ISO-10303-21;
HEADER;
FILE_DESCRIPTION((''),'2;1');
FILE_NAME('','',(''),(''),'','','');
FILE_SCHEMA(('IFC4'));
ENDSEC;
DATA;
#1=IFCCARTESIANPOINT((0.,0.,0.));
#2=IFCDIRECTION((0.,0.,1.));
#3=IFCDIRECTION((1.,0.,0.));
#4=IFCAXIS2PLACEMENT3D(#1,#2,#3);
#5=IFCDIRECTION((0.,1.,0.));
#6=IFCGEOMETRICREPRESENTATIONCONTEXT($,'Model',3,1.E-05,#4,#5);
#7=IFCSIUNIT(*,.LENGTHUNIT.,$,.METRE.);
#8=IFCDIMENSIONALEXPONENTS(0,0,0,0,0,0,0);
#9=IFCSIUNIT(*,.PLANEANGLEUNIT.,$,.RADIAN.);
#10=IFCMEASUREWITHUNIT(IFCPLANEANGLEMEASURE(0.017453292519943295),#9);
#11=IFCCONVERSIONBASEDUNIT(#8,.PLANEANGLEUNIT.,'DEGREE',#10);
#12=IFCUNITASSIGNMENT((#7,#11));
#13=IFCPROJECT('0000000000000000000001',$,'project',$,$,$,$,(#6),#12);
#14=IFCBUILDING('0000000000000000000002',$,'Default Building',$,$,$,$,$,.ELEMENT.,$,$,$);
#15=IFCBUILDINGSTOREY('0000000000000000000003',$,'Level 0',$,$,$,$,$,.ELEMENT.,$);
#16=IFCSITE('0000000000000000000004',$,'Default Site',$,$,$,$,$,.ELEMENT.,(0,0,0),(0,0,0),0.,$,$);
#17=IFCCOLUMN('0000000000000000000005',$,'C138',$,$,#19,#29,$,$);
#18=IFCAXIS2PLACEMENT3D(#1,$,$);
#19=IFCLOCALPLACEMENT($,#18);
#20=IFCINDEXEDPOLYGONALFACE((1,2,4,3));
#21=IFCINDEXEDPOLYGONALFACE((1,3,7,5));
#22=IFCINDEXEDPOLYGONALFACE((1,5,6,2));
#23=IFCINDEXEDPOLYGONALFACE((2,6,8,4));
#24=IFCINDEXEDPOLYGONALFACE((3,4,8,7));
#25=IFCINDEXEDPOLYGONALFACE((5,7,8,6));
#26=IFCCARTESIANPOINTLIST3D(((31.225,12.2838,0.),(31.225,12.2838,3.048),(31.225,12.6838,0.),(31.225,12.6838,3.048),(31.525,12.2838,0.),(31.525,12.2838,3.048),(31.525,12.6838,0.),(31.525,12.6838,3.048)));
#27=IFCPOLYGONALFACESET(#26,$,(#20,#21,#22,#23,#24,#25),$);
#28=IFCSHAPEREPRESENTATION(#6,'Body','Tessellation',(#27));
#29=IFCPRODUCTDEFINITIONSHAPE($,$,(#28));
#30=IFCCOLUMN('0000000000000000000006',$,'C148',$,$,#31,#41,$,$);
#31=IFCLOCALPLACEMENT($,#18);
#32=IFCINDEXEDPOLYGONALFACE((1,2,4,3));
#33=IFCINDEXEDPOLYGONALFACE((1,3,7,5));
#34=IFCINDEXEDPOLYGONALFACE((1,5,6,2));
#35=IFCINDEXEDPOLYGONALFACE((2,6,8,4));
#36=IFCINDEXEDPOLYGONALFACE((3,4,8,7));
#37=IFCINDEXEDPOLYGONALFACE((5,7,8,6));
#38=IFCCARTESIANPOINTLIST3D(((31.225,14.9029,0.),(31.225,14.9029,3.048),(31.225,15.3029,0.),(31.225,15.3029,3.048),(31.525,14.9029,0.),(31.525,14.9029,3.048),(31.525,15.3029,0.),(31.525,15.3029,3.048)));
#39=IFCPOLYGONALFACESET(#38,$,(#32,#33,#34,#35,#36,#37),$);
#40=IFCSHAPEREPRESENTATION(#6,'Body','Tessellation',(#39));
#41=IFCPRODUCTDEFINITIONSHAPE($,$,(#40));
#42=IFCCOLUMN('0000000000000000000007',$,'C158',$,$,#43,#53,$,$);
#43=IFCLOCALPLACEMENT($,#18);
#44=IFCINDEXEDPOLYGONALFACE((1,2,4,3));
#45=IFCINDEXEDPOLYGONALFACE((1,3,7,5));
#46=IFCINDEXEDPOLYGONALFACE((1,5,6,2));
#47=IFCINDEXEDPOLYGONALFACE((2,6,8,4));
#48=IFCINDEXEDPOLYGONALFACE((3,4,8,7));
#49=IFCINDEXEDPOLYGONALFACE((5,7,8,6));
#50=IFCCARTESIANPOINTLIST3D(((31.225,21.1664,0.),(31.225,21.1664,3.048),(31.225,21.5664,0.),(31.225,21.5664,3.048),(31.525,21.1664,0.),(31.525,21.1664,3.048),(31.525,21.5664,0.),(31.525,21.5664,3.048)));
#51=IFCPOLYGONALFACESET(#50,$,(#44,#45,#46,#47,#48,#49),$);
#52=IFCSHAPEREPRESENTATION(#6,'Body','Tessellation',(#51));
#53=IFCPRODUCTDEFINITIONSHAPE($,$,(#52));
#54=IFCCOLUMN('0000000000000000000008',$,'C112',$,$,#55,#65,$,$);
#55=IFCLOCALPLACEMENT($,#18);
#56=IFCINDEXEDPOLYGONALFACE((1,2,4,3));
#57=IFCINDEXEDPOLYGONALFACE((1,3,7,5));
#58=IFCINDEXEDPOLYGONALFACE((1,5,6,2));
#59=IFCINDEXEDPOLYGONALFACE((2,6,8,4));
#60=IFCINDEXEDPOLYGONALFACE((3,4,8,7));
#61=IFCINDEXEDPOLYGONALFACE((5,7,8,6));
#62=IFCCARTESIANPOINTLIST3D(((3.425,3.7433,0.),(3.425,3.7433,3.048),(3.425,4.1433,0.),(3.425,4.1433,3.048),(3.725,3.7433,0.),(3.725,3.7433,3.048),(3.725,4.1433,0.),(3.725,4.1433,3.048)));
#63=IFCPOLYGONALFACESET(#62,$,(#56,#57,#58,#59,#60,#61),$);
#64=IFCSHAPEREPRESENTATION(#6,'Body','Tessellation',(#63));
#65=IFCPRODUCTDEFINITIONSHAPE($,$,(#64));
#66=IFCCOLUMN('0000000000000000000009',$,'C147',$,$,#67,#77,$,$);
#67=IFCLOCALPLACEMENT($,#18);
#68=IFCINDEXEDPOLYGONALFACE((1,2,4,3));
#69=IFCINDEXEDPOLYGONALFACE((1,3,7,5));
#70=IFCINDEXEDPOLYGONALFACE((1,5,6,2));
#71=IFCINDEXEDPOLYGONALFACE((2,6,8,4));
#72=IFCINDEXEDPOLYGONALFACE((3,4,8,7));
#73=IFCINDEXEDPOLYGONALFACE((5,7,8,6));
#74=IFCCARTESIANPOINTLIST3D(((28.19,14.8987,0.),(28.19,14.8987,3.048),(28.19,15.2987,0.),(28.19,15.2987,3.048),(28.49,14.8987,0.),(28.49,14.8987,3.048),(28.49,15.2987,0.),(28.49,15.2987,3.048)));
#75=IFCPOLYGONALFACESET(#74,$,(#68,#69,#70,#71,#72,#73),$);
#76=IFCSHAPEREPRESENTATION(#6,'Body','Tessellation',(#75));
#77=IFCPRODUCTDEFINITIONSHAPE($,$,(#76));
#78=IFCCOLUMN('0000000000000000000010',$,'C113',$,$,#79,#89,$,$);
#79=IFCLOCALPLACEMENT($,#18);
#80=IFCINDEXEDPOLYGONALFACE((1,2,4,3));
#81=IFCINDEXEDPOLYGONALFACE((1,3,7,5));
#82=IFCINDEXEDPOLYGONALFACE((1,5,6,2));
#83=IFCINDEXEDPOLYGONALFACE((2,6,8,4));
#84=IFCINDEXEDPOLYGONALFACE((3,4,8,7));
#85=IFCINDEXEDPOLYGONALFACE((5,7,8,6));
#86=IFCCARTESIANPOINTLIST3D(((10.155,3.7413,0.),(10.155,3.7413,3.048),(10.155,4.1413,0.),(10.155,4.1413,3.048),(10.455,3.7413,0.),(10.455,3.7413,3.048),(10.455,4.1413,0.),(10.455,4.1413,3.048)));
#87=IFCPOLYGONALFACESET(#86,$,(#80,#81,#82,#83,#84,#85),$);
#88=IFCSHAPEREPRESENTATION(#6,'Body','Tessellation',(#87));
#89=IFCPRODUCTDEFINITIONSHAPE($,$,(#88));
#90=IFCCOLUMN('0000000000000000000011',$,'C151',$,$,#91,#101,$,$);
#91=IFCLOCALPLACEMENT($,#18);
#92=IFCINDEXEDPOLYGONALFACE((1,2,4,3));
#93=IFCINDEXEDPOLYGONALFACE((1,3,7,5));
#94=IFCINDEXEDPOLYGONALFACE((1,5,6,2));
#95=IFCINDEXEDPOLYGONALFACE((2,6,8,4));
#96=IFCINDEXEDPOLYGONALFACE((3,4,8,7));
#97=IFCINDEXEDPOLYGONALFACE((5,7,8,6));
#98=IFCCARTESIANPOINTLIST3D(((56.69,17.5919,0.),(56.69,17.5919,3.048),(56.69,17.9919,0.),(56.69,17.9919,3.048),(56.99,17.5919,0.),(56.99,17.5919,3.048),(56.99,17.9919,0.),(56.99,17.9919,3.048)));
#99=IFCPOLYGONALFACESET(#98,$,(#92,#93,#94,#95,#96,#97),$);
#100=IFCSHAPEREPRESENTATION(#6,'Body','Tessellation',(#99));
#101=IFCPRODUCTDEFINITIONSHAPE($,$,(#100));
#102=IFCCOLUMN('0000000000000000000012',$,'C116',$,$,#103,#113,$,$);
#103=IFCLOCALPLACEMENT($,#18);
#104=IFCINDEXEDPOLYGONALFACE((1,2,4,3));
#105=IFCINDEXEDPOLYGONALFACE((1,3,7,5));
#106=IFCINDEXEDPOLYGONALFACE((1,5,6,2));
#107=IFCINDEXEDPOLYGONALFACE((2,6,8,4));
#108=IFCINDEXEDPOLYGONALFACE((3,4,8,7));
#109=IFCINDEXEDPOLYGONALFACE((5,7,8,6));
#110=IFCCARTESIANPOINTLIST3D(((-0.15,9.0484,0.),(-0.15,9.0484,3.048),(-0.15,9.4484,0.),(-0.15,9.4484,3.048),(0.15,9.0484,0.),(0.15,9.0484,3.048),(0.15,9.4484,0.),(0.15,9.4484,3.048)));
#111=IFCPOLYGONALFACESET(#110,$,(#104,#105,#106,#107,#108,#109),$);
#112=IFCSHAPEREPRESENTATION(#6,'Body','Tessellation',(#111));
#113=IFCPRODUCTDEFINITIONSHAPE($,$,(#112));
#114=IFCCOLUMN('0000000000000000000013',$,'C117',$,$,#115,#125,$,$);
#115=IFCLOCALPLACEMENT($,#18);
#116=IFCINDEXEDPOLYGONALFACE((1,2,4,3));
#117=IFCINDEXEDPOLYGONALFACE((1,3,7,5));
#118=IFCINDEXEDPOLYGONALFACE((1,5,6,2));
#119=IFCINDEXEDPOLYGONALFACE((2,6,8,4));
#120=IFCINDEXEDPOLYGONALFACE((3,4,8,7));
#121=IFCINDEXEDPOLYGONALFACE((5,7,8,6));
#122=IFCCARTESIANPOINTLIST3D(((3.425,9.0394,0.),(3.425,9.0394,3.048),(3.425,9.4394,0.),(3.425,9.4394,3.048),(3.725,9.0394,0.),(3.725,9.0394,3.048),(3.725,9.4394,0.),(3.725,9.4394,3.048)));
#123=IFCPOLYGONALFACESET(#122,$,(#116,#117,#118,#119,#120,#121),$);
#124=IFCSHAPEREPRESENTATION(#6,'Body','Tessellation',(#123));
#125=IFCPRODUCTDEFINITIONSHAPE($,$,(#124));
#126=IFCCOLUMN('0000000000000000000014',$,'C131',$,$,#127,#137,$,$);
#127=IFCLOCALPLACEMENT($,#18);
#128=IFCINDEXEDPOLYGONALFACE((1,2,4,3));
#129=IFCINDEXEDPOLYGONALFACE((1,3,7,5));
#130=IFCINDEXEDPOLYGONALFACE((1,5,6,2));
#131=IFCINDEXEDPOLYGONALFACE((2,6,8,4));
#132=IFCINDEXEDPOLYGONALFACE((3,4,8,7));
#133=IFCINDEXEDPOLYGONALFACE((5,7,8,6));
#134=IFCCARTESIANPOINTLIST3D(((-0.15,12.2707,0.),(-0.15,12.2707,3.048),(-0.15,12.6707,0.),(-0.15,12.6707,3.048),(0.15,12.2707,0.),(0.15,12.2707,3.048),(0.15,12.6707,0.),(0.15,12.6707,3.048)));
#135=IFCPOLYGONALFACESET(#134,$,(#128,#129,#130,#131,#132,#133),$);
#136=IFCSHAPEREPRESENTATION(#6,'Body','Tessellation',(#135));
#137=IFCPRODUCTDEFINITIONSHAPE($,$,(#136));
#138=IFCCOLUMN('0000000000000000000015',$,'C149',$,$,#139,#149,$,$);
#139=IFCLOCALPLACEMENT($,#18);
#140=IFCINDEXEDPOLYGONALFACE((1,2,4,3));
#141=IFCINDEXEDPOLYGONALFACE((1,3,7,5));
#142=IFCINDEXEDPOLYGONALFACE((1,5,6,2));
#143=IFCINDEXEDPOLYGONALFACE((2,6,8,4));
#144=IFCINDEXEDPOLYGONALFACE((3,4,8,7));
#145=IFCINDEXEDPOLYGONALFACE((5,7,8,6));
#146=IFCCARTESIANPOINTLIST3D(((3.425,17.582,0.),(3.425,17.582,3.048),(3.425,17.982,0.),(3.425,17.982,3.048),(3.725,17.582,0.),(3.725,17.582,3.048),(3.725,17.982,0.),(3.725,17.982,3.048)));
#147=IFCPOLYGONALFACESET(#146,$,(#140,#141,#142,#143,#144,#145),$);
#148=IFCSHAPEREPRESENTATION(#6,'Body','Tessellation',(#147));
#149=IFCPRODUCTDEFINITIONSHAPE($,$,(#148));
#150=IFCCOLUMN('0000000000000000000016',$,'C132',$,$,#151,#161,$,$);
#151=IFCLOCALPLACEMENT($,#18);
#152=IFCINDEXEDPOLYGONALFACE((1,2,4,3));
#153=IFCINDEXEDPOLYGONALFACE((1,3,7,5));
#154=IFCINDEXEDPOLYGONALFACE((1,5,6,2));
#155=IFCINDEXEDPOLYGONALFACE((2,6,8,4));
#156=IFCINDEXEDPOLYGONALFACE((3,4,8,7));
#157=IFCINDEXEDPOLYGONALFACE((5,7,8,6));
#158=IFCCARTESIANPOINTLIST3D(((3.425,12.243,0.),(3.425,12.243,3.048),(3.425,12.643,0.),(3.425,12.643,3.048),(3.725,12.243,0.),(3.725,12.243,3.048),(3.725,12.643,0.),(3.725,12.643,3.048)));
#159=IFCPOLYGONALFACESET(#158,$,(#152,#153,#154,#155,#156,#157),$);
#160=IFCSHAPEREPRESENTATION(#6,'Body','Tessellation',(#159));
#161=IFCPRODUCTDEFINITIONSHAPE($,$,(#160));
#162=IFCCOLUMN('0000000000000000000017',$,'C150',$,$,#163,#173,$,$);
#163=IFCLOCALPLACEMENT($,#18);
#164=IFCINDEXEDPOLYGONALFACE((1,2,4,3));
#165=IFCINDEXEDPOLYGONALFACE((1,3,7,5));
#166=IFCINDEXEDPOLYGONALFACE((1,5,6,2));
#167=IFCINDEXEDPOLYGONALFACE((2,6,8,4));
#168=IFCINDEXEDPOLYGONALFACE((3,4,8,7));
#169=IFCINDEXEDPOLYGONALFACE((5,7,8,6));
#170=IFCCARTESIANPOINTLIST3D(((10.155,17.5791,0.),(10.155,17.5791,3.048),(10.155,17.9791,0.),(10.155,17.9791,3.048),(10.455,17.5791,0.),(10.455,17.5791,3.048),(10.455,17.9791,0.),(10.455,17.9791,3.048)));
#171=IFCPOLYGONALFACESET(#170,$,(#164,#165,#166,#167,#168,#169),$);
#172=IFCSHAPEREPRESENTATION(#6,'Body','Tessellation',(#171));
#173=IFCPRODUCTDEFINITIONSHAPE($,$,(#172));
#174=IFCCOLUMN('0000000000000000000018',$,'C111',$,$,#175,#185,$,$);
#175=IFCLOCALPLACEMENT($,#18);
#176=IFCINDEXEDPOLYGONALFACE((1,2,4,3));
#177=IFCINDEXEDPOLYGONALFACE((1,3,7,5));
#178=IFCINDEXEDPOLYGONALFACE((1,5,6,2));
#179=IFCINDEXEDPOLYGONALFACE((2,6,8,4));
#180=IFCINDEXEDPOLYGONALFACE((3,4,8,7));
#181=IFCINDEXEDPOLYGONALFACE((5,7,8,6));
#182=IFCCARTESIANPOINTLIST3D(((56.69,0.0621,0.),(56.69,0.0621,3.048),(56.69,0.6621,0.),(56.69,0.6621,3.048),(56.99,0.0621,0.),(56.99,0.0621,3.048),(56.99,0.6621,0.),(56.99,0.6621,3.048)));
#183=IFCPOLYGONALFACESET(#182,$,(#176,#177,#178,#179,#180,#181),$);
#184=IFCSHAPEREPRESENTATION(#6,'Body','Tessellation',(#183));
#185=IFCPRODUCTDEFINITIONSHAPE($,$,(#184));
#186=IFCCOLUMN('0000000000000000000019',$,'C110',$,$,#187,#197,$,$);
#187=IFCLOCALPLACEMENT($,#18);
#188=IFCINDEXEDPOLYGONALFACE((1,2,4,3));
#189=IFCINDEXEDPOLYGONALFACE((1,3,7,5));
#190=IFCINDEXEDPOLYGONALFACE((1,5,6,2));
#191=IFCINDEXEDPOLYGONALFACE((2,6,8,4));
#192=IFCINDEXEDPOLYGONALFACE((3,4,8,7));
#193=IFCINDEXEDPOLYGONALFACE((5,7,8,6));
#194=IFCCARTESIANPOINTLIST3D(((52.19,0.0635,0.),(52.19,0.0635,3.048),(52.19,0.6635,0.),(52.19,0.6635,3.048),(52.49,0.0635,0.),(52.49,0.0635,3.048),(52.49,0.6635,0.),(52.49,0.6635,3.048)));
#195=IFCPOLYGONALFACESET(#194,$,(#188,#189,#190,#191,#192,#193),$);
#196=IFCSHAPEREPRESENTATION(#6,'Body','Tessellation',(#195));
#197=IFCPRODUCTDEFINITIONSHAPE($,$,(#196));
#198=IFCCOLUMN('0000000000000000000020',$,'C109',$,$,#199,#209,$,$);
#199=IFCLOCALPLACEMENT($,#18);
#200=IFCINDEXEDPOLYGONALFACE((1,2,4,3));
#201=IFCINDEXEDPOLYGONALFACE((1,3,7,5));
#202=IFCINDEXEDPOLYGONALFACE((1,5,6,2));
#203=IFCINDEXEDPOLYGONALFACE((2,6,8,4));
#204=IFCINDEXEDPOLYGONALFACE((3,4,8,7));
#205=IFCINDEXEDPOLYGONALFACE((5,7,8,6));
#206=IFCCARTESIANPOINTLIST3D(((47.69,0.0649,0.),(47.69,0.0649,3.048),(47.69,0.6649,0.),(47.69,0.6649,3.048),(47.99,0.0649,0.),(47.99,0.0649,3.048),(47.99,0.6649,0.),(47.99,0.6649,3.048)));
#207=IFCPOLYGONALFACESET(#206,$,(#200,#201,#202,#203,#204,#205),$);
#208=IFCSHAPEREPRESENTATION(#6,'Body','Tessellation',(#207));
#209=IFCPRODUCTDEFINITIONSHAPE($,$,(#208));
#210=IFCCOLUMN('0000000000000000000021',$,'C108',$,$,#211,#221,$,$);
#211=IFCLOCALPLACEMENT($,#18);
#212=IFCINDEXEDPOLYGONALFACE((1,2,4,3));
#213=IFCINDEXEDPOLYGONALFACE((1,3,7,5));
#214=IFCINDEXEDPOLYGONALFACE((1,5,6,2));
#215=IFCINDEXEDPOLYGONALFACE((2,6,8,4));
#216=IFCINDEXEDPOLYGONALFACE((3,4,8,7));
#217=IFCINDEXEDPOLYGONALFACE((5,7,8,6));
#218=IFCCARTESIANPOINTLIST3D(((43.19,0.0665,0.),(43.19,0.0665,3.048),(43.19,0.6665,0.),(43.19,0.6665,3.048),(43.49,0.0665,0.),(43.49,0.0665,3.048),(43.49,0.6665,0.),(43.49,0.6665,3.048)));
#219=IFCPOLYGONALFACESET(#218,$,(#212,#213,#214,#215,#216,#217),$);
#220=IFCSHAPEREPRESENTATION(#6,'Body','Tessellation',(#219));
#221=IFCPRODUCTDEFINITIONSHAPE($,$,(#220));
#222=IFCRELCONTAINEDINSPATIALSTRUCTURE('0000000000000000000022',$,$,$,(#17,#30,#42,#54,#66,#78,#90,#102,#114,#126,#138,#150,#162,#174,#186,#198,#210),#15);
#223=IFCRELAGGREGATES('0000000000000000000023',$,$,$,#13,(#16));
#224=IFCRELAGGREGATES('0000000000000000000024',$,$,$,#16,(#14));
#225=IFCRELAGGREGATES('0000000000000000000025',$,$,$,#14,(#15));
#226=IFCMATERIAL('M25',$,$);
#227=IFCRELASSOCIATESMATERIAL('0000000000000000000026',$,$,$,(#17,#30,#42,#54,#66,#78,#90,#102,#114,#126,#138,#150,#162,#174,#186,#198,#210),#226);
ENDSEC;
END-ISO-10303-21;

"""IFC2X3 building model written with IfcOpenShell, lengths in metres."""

from ifc_helpers import new_model, entity, si_unit, converted_unit, direction, frame, frame_2d, origin_with_axes, place, context, project, spatial, rectangle, extrude, material, element, save


model = new_model("IFC2X3")

# Units and contexts
model_context = context("Model", 3, precision=1e-05, world=origin_with_axes(), true_north=direction((0.0, 1.0, 0.0)))
ifc_project = project(units=[si_unit("LENGTHUNIT", "METRE"), converted_unit("PLANEANGLEUNIT", "DEGREE", entity("IfcPlaneAngleMeasure", 0.017453292519943295), si_unit("PLANEANGLEUNIT", "RADIAN"), dimensions=[0, 0, 0, 0, 0, 0, 0])], contexts=[model_context])

# Site, building, storey
site = spatial("IfcSite", under=ifc_project, Name="Default Site", CompositionType="ELEMENT", RefLatitude=(0, 0, 0), RefLongitude=(0, 0, 0), RefElevation=0.0)
building = spatial("IfcBuilding", under=site, Name="Default Building", CompositionType="ELEMENT")
storey = spatial("IfcBuildingStorey", under=building, Name="Level 0", CompositionType="ELEMENT")

# Columns
ifc_material = material(Name="M25")
placement = place(None, origin_with_axes())
element("IfcColumn", 1, at=placement, inside=storey, material=ifc_material, Name="C138", context=model_context, shape_type="SweptSolid", body=[
    extrude(rectangle(XDim=0.3, YDim=0.4, at=frame_2d((0.0, 0.0), x_axis=(1.0, 0.0, 0.0))), frame((31.375, 12.4838, 0.0), z_axis=(0.0, 0.0, 1.0), x_axis=(1.0, 0.0, 0.0)), (0.0, 0.0, 1.0), 3.048),
])
element("IfcColumn", 2, at=placement, inside=storey, material=ifc_material, Name="C148", context=model_context, shape_type="SweptSolid", body=[
    extrude(rectangle(XDim=0.3, YDim=0.4, at=frame_2d((0.0, 0.0), x_axis=(1.0, 0.0, 0.0))), frame((31.375, 15.1029, 0.0), z_axis=(0.0, 0.0, 1.0), x_axis=(1.0, 0.0, 0.0)), (0.0, 0.0, 1.0), 3.048),
])
element("IfcColumn", 3, at=placement, inside=storey, material=ifc_material, Name="C158", context=model_context, shape_type="SweptSolid", body=[
    extrude(rectangle(XDim=0.3, YDim=0.4, at=frame_2d((0.0, 0.0), x_axis=(1.0, 0.0, 0.0))), frame((31.375, 21.3664, 0.0), z_axis=(0.0, 0.0, 1.0), x_axis=(1.0, 0.0, 0.0)), (0.0, 0.0, 1.0), 3.048),
])
element("IfcColumn", 4, at=placement, inside=storey, material=ifc_material, Name="C112", context=model_context, shape_type="SweptSolid", body=[
    extrude(rectangle(XDim=0.3, YDim=0.4, at=frame_2d((0.0, 0.0), x_axis=(1.0, 0.0, 0.0))), frame((3.575, 3.9433, 0.0), z_axis=(0.0, 0.0, 1.0), x_axis=(1.0, 0.0, 0.0)), (0.0, 0.0, 1.0), 3.048),
])
element("IfcColumn", 5, at=placement, inside=storey, material=ifc_material, Name="C147", context=model_context, shape_type="SweptSolid", body=[
    extrude(rectangle(XDim=0.3, YDim=0.4, at=frame_2d((0.0, 0.0), x_axis=(1.0, 0.0, 0.0))), frame((28.34, 15.0987, 0.0), z_axis=(0.0, 0.0, 1.0), x_axis=(1.0, 0.0, 0.0)), (0.0, 0.0, 1.0), 3.048),
])
element("IfcColumn", 6, at=placement, inside=storey, material=ifc_material, Name="C113", context=model_context, shape_type="SweptSolid", body=[
    extrude(rectangle(XDim=0.3, YDim=0.4, at=frame_2d((0.0, 0.0), x_axis=(1.0, 0.0, 0.0))), frame((10.305, 3.9413, 0.0), z_axis=(0.0, 0.0, 1.0), x_axis=(1.0, 0.0, 0.0)), (0.0, 0.0, 1.0), 3.048),
])
element("IfcColumn", 7, at=placement, inside=storey, material=ifc_material, Name="C151", context=model_context, shape_type="SweptSolid", body=[
    extrude(rectangle(XDim=0.3, YDim=0.4, at=frame_2d((0.0, 0.0), x_axis=(1.0, 0.0, 0.0))), frame((56.84, 17.7919, 0.0), z_axis=(0.0, 0.0, 1.0), x_axis=(1.0, 0.0, 0.0)), (0.0, 0.0, 1.0), 3.048),
])
element("IfcColumn", 8, at=placement, inside=storey, material=ifc_material, Name="C116", context=model_context, shape_type="SweptSolid", body=[
    extrude(rectangle(XDim=0.3, YDim=0.4, at=frame_2d((0.0, 0.0), x_axis=(1.0, 0.0, 0.0))), frame((0.0, 9.2484, 0.0), z_axis=(0.0, 0.0, 1.0), x_axis=(1.0, 0.0, 0.0)), (0.0, 0.0, 1.0), 3.048),
])
element("IfcColumn", 9, at=placement, inside=storey, material=ifc_material, Name="C117", context=model_context, shape_type="SweptSolid", body=[
    extrude(rectangle(XDim=0.3, YDim=0.4, at=frame_2d((0.0, 0.0), x_axis=(1.0, 0.0, 0.0))), frame((3.575, 9.2394, 0.0), z_axis=(0.0, 0.0, 1.0), x_axis=(1.0, 0.0, 0.0)), (0.0, 0.0, 1.0), 3.048),
])
element("IfcColumn", 10, at=placement, inside=storey, material=ifc_material, Name="C131", context=model_context, shape_type="SweptSolid", body=[
    extrude(rectangle(XDim=0.3, YDim=0.4, at=frame_2d((0.0, 0.0), x_axis=(1.0, 0.0, 0.0))), frame((0.0, 12.4707, 0.0), z_axis=(0.0, 0.0, 1.0), x_axis=(1.0, 0.0, 0.0)), (0.0, 0.0, 1.0), 3.048),
])
element("IfcColumn", 11, at=placement, inside=storey, material=ifc_material, Name="C149", context=model_context, shape_type="SweptSolid", body=[
    extrude(rectangle(XDim=0.3, YDim=0.4, at=frame_2d((0.0, 0.0), x_axis=(1.0, 0.0, 0.0))), frame((3.575, 17.782, 0.0), z_axis=(0.0, 0.0, 1.0), x_axis=(1.0, 0.0, 0.0)), (0.0, 0.0, 1.0), 3.048),
])
element("IfcColumn", 12, at=placement, inside=storey, material=ifc_material, Name="C132", context=model_context, shape_type="SweptSolid", body=[
    extrude(rectangle(XDim=0.3, YDim=0.4, at=frame_2d((0.0, 0.0), x_axis=(1.0, 0.0, 0.0))), frame((3.575, 12.443, 0.0), z_axis=(0.0, 0.0, 1.0), x_axis=(1.0, 0.0, 0.0)), (0.0, 0.0, 1.0), 3.048),
])
element("IfcColumn", 13, at=placement, inside=storey, material=ifc_material, Name="C150", context=model_context, shape_type="SweptSolid", body=[
    extrude(rectangle(XDim=0.3, YDim=0.4, at=frame_2d((0.0, 0.0), x_axis=(1.0, 0.0, 0.0))), frame((10.305, 17.7791, 0.0), z_axis=(0.0, 0.0, 1.0), x_axis=(1.0, 0.0, 0.0)), (0.0, 0.0, 1.0), 3.048),
])
element("IfcColumn", 14, at=placement, inside=storey, material=ifc_material, Name="C111", context=model_context, shape_type="SweptSolid", body=[
    extrude(rectangle(XDim=0.3, YDim=0.6, at=frame_2d((0.0, 0.0), x_axis=(1.0, 0.0, 0.0))), frame((56.84, 0.3621, 0.0), z_axis=(0.0, 0.0, 1.0), x_axis=(1.0, 0.0, 0.0)), (0.0, 0.0, 1.0), 3.048),
])
element("IfcColumn", 15, at=placement, inside=storey, material=ifc_material, Name="C110", context=model_context, shape_type="SweptSolid", body=[
    extrude(rectangle(XDim=0.3, YDim=0.6, at=frame_2d((0.0, 0.0), x_axis=(1.0, 0.0, 0.0))), frame((52.34, 0.3635, 0.0), z_axis=(0.0, 0.0, 1.0), x_axis=(1.0, 0.0, 0.0)), (0.0, 0.0, 1.0), 3.048),
])
element("IfcColumn", 16, at=placement, inside=storey, material=ifc_material, Name="C109", context=model_context, shape_type="SweptSolid", body=[
    extrude(rectangle(XDim=0.3, YDim=0.6, at=frame_2d((0.0, 0.0), x_axis=(1.0, 0.0, 0.0))), frame((47.84, 0.3649, 0.0), z_axis=(0.0, 0.0, 1.0), x_axis=(1.0, 0.0, 0.0)), (0.0, 0.0, 1.0), 3.048),
])
element("IfcColumn", 17, at=placement, inside=storey, material=ifc_material, Name="C108", context=model_context, shape_type="SweptSolid", body=[
    extrude(rectangle(XDim=0.3, YDim=0.6, at=frame_2d((0.0, 0.0), x_axis=(1.0, 0.0, 0.0))), frame((43.34, 0.3665, 0.0), z_axis=(0.0, 0.0, 1.0), x_axis=(1.0, 0.0, 0.0)), (0.0, 0.0, 1.0), 3.048),
])

save(model, "model.ifc")
